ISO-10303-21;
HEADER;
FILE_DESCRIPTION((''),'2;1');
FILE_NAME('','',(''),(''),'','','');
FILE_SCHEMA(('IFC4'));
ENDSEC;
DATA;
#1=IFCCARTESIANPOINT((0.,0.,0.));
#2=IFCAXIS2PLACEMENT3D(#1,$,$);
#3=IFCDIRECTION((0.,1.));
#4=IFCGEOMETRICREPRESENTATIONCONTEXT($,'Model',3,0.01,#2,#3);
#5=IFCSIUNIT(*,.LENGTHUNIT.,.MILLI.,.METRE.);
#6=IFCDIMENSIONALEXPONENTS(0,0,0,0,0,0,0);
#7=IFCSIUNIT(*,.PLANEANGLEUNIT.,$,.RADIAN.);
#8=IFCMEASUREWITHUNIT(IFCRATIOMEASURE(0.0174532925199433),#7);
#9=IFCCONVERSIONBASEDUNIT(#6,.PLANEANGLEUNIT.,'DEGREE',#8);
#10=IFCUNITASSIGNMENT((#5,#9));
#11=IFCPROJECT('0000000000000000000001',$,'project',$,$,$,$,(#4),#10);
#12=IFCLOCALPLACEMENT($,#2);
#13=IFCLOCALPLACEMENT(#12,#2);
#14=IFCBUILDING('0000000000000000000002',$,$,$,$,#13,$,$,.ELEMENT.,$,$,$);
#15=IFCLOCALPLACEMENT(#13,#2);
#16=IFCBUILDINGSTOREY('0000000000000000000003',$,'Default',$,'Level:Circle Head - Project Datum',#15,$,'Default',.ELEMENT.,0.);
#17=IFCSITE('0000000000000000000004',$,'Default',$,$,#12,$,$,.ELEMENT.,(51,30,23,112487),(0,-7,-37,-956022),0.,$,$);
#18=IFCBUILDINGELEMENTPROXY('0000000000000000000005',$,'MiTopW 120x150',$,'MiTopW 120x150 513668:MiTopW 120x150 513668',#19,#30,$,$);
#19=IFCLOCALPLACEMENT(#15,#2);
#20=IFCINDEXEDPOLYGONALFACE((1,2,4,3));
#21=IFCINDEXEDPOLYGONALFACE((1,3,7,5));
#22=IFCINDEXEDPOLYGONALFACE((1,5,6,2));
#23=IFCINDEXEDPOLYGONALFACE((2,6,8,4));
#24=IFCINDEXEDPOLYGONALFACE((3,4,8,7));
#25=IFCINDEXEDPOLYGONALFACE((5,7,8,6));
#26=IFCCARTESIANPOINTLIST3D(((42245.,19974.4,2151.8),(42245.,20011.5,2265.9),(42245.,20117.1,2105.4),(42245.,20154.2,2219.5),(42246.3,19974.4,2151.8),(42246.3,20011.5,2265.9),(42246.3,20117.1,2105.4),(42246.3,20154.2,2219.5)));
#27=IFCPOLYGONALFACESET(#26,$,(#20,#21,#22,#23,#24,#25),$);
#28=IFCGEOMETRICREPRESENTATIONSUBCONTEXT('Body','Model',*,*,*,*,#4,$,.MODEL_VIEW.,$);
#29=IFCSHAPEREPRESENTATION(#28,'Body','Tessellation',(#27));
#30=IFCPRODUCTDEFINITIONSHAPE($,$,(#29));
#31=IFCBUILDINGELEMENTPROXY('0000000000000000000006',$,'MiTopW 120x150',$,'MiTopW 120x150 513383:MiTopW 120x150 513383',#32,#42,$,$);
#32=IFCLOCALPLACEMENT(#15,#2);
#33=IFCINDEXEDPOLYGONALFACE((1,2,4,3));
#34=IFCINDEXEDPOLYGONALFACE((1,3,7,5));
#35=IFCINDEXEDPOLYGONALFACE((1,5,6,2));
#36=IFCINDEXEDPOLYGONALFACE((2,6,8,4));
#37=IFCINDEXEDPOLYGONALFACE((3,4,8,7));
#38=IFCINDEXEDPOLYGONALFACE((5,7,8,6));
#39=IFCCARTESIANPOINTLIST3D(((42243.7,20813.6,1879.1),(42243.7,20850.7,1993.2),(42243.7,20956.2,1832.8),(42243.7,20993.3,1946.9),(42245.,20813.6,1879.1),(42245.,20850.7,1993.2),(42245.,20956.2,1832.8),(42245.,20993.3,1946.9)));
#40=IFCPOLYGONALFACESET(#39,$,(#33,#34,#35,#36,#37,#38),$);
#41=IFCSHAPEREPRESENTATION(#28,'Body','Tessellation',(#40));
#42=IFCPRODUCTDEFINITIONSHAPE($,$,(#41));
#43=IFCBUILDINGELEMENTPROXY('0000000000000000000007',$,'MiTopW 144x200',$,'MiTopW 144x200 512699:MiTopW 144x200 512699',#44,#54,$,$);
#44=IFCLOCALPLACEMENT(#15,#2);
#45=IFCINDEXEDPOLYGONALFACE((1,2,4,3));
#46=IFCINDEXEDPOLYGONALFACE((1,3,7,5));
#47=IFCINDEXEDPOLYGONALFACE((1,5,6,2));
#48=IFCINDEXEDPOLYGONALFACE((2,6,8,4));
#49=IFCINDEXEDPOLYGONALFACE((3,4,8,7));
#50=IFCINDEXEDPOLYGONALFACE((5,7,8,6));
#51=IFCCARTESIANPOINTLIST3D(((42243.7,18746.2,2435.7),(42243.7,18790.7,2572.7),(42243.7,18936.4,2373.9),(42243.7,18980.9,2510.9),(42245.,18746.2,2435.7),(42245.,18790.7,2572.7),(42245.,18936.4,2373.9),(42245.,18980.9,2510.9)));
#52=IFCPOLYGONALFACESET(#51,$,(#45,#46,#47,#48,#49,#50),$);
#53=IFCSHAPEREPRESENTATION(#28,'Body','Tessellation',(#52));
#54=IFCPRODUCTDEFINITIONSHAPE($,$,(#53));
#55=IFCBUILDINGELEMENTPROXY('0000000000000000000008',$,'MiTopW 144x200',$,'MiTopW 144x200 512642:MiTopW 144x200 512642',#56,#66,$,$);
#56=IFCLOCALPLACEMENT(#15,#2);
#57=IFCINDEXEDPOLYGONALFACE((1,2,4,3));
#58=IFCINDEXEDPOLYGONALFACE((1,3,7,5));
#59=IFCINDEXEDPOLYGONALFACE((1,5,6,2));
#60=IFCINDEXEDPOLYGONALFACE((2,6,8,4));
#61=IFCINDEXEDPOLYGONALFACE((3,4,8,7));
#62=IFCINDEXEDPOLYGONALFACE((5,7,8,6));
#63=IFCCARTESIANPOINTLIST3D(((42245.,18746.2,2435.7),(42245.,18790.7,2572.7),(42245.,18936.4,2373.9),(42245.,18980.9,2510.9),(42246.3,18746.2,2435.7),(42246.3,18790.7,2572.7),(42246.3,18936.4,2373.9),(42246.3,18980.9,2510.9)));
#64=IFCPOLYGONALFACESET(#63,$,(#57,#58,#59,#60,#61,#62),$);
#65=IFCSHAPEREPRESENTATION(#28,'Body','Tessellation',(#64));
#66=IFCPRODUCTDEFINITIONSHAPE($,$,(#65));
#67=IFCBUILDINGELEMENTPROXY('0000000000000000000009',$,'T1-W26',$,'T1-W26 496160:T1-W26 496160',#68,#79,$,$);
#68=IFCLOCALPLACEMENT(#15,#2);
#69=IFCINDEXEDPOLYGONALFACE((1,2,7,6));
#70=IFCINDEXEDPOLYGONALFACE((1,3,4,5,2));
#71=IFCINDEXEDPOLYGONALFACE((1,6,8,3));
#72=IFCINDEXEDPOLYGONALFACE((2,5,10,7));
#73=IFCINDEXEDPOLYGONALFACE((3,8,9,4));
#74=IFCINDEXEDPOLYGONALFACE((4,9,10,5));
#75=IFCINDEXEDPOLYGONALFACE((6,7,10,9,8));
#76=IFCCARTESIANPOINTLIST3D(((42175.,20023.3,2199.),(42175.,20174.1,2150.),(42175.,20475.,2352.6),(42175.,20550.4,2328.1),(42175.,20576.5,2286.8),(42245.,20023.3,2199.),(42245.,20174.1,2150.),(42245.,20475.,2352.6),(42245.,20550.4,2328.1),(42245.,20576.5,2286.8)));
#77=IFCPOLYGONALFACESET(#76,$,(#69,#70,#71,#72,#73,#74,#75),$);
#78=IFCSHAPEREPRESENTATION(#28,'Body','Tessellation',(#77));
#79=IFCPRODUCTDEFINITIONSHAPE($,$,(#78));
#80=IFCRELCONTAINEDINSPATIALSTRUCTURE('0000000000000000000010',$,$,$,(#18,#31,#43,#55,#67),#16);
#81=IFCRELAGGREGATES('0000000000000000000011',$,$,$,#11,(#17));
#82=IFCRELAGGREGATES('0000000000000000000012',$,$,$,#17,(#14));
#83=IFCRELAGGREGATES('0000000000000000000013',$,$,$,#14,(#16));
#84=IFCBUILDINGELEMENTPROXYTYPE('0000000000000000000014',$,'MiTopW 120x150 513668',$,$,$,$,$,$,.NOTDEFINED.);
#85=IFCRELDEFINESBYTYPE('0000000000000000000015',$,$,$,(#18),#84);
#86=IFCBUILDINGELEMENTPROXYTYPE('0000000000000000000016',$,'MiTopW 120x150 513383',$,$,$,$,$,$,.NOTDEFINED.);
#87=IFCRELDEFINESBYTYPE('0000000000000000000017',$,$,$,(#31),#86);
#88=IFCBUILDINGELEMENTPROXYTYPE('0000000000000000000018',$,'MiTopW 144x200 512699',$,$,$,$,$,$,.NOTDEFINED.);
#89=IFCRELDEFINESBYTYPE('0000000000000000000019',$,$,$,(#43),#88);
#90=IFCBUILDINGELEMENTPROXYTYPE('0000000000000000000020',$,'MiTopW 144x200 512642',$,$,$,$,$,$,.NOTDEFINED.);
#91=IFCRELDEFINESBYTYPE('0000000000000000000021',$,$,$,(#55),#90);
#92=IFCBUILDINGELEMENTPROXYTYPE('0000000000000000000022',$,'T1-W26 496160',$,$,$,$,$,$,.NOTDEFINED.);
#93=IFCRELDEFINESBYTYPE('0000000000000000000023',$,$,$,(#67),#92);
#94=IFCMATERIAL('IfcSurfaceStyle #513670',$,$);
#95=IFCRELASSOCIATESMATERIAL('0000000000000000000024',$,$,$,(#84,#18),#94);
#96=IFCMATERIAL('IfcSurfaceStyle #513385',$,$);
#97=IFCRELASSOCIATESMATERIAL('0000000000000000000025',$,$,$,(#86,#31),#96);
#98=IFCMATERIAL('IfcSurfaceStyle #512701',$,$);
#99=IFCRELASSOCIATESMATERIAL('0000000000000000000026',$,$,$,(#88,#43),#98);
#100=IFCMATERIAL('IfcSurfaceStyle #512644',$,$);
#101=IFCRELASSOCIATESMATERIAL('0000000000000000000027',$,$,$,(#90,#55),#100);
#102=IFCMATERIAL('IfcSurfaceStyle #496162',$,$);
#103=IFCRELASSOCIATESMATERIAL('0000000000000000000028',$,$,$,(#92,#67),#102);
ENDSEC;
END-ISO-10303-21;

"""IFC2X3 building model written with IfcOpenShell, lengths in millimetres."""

from ifc_helpers import new_model, entity, si_unit, converted_unit, direction, frame, origin, place, context, subcontext, project, spatial, polyline, outline, extrude, source, transform, mapped, material, type_object, type_shapes, element, save


model = new_model("IFC2X3")

# Units and contexts
model_context = context("Model", 3, precision=0.01, world=origin(), true_north=direction((0.0, 1.0)))
body_context = subcontext(model_context, "Body", "Model", "MODEL_VIEW")
ifc_project = project(units=[si_unit("LENGTHUNIT", "METRE", prefix="MILLI"), converted_unit("PLANEANGLEUNIT", "DEGREE", entity("IfcRatioMeasure", 0.0174532925199433), si_unit("PLANEANGLEUNIT", "RADIAN"), dimensions=[0, 0, 0, 0, 0, 0, 0])], contexts=[model_context])

# Site, building, storey
site_placement = place(None, origin())
site = spatial("IfcSite", under=ifc_project, at=site_placement, Name="Default", CompositionType="ELEMENT", RefLatitude=(51, 30, 23, 112487), RefLongitude=(0, -7, -37, -956022), RefElevation=0.0)
building_placement = place(site_placement, origin())
building = spatial("IfcBuilding", under=site, at=building_placement, CompositionType="ELEMENT")
storey_placement = place(building_placement, origin())
storey = spatial("IfcBuildingStorey", under=building, at=storey_placement, Name="Default", ObjectType="Level:Circle Head - Project Datum", LongName="Default", CompositionType="ELEMENT", Elevation=0.0)

# Building element proxies
ifc_material_1 = material(Name="IfcSurfaceStyle #513670")
building_element_proxy_type_1 = type_object("IfcBuildingElementProxyType", Name="MiTopW 120x150 513668", PredefinedType="NOTDEFINED", material=ifc_material_1)
shared_shape_1 = source(origin(), body_context, "Body", "SweptSolid", [
    extrude(outline(polyline([(-75.0, -60.0), (75.0, -60.0), (75.0, 60.0), (-75.0, 60.0), (-75.0, -60.0)])), frame((75.0, 60.0, 0.0), z_axis=(0.0, 0.0, 1.0), x_axis=(-1.0, 0.0, 0.0)), (0.0, 0.0, 1.0), 1.3),
])
type_shapes(building_element_proxy_type_1, [shared_shape_1])
proxy_1_placement = place(building_placement, frame((42246.3, 20117.1, 2105.4), z_axis=(-1.0, 0.0, 0.0), x_axis=(0.0, -0.951057, 0.309017)))
element("IfcBuildingElementProxy", 1, at=proxy_1_placement, inside=storey, type_object=building_element_proxy_type_1, material=ifc_material_1, Name="MiTopW 120x150", ObjectType="MiTopW 120x150 513668:MiTopW 120x150 513668", context=body_context, shape_type="MappedRepresentation", body=[
    mapped(shared_shape_1, transform((0.0, 0.0, 0.0), scale=1.0)),
])
ifc_material_2 = material(Name="IfcSurfaceStyle #513385")
building_element_proxy_type_2 = type_object("IfcBuildingElementProxyType", Name="MiTopW 120x150 513383", PredefinedType="NOTDEFINED", material=ifc_material_2)
shared_shape_2 = source(origin(), body_context, "Body", "SweptSolid", [
    extrude(outline(polyline([(-75.0, -60.0), (75.0, -60.0), (75.0, 60.0), (-75.0, 60.0), (-75.0, -60.0)])), frame((75.0, 60.0, 0.0), z_axis=(0.0, 0.0, 1.0), x_axis=(-1.0, 0.0, 0.0)), (0.0, 0.0, 1.0), 1.3),
])
type_shapes(building_element_proxy_type_2, [shared_shape_2])
proxy_2_placement = place(building_placement, frame((42245.0, 20956.2, 1832.8), z_axis=(-1.0, 0.0, 0.0), x_axis=(0.0, -0.951057, 0.309017)))
element("IfcBuildingElementProxy", 2, at=proxy_2_placement, inside=storey, type_object=building_element_proxy_type_2, material=ifc_material_2, Name="MiTopW 120x150", ObjectType="MiTopW 120x150 513383:MiTopW 120x150 513383", context=body_context, shape_type="MappedRepresentation", body=[
    mapped(shared_shape_2, transform((0.0, 0.0, 0.0), scale=1.0)),
])
ifc_material_3 = material(Name="IfcSurfaceStyle #512701")
building_element_proxy_type_3 = type_object("IfcBuildingElementProxyType", Name="MiTopW 144x200 512699", PredefinedType="NOTDEFINED", material=ifc_material_3)
shared_shape_3 = source(origin(), body_context, "Body", "SweptSolid", [
    extrude(outline(polyline([(-100.0, -72.0), (100.0, -72.0), (100.0, 72.0), (-100.0, 72.0), (-100.0, -72.0)])), frame((100.0, 72.0, 0.0), z_axis=(0.0, 0.0, 1.0), x_axis=(-1.0, 0.0, 0.0)), (0.0, 0.0, 1.0), 1.3),
])
type_shapes(building_element_proxy_type_3, [shared_shape_3])
proxy_3_placement = place(building_placement, frame((42245.0, 18936.4, 2373.9), z_axis=(-1.0, 0.0, 0.0), x_axis=(0.0, -0.951057, 0.309017)))
element("IfcBuildingElementProxy", 3, at=proxy_3_placement, inside=storey, type_object=building_element_proxy_type_3, material=ifc_material_3, Name="MiTopW 144x200", ObjectType="MiTopW 144x200 512699:MiTopW 144x200 512699", context=body_context, shape_type="MappedRepresentation", body=[
    mapped(shared_shape_3, transform((0.0, 0.0, 0.0), scale=1.0)),
])
ifc_material_4 = material(Name="IfcSurfaceStyle #512644")
building_element_proxy_type_4 = type_object("IfcBuildingElementProxyType", Name="MiTopW 144x200 512642", PredefinedType="NOTDEFINED", material=ifc_material_4)
shared_shape_4 = source(origin(), body_context, "Body", "SweptSolid", [
    extrude(outline(polyline([(-100.0, -72.0), (100.0, -72.0), (100.0, 72.0), (-100.0, 72.0), (-100.0, -72.0)])), frame((100.0, 72.0, 0.0), z_axis=(0.0, 0.0, 1.0), x_axis=(-1.0, 0.0, 0.0)), (0.0, 0.0, 1.0), 1.3),
])
type_shapes(building_element_proxy_type_4, [shared_shape_4])
proxy_4_placement = place(building_placement, frame((42246.3, 18936.4, 2373.9), z_axis=(-1.0, 0.0, 0.0), x_axis=(0.0, -0.951057, 0.309017)))
element("IfcBuildingElementProxy", 4, at=proxy_4_placement, inside=storey, type_object=building_element_proxy_type_4, material=ifc_material_4, Name="MiTopW 144x200", ObjectType="MiTopW 144x200 512642:MiTopW 144x200 512642", context=body_context, shape_type="MappedRepresentation", body=[
    mapped(shared_shape_4, transform((0.0, 0.0, 0.0), scale=1.0)),
])
ifc_material_5 = material(Name="IfcSurfaceStyle #496162")
building_element_proxy_type_5 = type_object("IfcBuildingElementProxyType", Name="T1-W26 496160", PredefinedType="NOTDEFINED", material=ifc_material_5)
shared_shape_5 = source(origin(), body_context, "Body", "SweptSolid", [
    extrude(outline(polyline([(-339.4, -47.5), (137.7, -47.5), (201.3, 0.0), (212.7, 47.5), (-212.3, 47.5), (-339.4, -47.5)])), frame((212.7, 47.5, 0.0), z_axis=(0.0, 0.0, 1.0), x_axis=(-1.0, 0.0, 0.0)), (0.0, 0.0, 1.0), 70.0),
])
type_shapes(building_element_proxy_type_5, [shared_shape_5])
proxy_5_placement = place(building_placement, frame((42245.0, 20576.5, 2286.8), z_axis=(-1.0, 0.0, 0.0), x_axis=(0.0, -0.946744, -0.321988)))
element("IfcBuildingElementProxy", 5, at=proxy_5_placement, inside=storey, type_object=building_element_proxy_type_5, material=ifc_material_5, Name="T1-W26", ObjectType="T1-W26 496160:T1-W26 496160", context=body_context, shape_type="MappedRepresentation", body=[
    mapped(shared_shape_5, transform((0.0, 0.0, 0.0), scale=1.0)),
])

save(model, "model.ifc")
